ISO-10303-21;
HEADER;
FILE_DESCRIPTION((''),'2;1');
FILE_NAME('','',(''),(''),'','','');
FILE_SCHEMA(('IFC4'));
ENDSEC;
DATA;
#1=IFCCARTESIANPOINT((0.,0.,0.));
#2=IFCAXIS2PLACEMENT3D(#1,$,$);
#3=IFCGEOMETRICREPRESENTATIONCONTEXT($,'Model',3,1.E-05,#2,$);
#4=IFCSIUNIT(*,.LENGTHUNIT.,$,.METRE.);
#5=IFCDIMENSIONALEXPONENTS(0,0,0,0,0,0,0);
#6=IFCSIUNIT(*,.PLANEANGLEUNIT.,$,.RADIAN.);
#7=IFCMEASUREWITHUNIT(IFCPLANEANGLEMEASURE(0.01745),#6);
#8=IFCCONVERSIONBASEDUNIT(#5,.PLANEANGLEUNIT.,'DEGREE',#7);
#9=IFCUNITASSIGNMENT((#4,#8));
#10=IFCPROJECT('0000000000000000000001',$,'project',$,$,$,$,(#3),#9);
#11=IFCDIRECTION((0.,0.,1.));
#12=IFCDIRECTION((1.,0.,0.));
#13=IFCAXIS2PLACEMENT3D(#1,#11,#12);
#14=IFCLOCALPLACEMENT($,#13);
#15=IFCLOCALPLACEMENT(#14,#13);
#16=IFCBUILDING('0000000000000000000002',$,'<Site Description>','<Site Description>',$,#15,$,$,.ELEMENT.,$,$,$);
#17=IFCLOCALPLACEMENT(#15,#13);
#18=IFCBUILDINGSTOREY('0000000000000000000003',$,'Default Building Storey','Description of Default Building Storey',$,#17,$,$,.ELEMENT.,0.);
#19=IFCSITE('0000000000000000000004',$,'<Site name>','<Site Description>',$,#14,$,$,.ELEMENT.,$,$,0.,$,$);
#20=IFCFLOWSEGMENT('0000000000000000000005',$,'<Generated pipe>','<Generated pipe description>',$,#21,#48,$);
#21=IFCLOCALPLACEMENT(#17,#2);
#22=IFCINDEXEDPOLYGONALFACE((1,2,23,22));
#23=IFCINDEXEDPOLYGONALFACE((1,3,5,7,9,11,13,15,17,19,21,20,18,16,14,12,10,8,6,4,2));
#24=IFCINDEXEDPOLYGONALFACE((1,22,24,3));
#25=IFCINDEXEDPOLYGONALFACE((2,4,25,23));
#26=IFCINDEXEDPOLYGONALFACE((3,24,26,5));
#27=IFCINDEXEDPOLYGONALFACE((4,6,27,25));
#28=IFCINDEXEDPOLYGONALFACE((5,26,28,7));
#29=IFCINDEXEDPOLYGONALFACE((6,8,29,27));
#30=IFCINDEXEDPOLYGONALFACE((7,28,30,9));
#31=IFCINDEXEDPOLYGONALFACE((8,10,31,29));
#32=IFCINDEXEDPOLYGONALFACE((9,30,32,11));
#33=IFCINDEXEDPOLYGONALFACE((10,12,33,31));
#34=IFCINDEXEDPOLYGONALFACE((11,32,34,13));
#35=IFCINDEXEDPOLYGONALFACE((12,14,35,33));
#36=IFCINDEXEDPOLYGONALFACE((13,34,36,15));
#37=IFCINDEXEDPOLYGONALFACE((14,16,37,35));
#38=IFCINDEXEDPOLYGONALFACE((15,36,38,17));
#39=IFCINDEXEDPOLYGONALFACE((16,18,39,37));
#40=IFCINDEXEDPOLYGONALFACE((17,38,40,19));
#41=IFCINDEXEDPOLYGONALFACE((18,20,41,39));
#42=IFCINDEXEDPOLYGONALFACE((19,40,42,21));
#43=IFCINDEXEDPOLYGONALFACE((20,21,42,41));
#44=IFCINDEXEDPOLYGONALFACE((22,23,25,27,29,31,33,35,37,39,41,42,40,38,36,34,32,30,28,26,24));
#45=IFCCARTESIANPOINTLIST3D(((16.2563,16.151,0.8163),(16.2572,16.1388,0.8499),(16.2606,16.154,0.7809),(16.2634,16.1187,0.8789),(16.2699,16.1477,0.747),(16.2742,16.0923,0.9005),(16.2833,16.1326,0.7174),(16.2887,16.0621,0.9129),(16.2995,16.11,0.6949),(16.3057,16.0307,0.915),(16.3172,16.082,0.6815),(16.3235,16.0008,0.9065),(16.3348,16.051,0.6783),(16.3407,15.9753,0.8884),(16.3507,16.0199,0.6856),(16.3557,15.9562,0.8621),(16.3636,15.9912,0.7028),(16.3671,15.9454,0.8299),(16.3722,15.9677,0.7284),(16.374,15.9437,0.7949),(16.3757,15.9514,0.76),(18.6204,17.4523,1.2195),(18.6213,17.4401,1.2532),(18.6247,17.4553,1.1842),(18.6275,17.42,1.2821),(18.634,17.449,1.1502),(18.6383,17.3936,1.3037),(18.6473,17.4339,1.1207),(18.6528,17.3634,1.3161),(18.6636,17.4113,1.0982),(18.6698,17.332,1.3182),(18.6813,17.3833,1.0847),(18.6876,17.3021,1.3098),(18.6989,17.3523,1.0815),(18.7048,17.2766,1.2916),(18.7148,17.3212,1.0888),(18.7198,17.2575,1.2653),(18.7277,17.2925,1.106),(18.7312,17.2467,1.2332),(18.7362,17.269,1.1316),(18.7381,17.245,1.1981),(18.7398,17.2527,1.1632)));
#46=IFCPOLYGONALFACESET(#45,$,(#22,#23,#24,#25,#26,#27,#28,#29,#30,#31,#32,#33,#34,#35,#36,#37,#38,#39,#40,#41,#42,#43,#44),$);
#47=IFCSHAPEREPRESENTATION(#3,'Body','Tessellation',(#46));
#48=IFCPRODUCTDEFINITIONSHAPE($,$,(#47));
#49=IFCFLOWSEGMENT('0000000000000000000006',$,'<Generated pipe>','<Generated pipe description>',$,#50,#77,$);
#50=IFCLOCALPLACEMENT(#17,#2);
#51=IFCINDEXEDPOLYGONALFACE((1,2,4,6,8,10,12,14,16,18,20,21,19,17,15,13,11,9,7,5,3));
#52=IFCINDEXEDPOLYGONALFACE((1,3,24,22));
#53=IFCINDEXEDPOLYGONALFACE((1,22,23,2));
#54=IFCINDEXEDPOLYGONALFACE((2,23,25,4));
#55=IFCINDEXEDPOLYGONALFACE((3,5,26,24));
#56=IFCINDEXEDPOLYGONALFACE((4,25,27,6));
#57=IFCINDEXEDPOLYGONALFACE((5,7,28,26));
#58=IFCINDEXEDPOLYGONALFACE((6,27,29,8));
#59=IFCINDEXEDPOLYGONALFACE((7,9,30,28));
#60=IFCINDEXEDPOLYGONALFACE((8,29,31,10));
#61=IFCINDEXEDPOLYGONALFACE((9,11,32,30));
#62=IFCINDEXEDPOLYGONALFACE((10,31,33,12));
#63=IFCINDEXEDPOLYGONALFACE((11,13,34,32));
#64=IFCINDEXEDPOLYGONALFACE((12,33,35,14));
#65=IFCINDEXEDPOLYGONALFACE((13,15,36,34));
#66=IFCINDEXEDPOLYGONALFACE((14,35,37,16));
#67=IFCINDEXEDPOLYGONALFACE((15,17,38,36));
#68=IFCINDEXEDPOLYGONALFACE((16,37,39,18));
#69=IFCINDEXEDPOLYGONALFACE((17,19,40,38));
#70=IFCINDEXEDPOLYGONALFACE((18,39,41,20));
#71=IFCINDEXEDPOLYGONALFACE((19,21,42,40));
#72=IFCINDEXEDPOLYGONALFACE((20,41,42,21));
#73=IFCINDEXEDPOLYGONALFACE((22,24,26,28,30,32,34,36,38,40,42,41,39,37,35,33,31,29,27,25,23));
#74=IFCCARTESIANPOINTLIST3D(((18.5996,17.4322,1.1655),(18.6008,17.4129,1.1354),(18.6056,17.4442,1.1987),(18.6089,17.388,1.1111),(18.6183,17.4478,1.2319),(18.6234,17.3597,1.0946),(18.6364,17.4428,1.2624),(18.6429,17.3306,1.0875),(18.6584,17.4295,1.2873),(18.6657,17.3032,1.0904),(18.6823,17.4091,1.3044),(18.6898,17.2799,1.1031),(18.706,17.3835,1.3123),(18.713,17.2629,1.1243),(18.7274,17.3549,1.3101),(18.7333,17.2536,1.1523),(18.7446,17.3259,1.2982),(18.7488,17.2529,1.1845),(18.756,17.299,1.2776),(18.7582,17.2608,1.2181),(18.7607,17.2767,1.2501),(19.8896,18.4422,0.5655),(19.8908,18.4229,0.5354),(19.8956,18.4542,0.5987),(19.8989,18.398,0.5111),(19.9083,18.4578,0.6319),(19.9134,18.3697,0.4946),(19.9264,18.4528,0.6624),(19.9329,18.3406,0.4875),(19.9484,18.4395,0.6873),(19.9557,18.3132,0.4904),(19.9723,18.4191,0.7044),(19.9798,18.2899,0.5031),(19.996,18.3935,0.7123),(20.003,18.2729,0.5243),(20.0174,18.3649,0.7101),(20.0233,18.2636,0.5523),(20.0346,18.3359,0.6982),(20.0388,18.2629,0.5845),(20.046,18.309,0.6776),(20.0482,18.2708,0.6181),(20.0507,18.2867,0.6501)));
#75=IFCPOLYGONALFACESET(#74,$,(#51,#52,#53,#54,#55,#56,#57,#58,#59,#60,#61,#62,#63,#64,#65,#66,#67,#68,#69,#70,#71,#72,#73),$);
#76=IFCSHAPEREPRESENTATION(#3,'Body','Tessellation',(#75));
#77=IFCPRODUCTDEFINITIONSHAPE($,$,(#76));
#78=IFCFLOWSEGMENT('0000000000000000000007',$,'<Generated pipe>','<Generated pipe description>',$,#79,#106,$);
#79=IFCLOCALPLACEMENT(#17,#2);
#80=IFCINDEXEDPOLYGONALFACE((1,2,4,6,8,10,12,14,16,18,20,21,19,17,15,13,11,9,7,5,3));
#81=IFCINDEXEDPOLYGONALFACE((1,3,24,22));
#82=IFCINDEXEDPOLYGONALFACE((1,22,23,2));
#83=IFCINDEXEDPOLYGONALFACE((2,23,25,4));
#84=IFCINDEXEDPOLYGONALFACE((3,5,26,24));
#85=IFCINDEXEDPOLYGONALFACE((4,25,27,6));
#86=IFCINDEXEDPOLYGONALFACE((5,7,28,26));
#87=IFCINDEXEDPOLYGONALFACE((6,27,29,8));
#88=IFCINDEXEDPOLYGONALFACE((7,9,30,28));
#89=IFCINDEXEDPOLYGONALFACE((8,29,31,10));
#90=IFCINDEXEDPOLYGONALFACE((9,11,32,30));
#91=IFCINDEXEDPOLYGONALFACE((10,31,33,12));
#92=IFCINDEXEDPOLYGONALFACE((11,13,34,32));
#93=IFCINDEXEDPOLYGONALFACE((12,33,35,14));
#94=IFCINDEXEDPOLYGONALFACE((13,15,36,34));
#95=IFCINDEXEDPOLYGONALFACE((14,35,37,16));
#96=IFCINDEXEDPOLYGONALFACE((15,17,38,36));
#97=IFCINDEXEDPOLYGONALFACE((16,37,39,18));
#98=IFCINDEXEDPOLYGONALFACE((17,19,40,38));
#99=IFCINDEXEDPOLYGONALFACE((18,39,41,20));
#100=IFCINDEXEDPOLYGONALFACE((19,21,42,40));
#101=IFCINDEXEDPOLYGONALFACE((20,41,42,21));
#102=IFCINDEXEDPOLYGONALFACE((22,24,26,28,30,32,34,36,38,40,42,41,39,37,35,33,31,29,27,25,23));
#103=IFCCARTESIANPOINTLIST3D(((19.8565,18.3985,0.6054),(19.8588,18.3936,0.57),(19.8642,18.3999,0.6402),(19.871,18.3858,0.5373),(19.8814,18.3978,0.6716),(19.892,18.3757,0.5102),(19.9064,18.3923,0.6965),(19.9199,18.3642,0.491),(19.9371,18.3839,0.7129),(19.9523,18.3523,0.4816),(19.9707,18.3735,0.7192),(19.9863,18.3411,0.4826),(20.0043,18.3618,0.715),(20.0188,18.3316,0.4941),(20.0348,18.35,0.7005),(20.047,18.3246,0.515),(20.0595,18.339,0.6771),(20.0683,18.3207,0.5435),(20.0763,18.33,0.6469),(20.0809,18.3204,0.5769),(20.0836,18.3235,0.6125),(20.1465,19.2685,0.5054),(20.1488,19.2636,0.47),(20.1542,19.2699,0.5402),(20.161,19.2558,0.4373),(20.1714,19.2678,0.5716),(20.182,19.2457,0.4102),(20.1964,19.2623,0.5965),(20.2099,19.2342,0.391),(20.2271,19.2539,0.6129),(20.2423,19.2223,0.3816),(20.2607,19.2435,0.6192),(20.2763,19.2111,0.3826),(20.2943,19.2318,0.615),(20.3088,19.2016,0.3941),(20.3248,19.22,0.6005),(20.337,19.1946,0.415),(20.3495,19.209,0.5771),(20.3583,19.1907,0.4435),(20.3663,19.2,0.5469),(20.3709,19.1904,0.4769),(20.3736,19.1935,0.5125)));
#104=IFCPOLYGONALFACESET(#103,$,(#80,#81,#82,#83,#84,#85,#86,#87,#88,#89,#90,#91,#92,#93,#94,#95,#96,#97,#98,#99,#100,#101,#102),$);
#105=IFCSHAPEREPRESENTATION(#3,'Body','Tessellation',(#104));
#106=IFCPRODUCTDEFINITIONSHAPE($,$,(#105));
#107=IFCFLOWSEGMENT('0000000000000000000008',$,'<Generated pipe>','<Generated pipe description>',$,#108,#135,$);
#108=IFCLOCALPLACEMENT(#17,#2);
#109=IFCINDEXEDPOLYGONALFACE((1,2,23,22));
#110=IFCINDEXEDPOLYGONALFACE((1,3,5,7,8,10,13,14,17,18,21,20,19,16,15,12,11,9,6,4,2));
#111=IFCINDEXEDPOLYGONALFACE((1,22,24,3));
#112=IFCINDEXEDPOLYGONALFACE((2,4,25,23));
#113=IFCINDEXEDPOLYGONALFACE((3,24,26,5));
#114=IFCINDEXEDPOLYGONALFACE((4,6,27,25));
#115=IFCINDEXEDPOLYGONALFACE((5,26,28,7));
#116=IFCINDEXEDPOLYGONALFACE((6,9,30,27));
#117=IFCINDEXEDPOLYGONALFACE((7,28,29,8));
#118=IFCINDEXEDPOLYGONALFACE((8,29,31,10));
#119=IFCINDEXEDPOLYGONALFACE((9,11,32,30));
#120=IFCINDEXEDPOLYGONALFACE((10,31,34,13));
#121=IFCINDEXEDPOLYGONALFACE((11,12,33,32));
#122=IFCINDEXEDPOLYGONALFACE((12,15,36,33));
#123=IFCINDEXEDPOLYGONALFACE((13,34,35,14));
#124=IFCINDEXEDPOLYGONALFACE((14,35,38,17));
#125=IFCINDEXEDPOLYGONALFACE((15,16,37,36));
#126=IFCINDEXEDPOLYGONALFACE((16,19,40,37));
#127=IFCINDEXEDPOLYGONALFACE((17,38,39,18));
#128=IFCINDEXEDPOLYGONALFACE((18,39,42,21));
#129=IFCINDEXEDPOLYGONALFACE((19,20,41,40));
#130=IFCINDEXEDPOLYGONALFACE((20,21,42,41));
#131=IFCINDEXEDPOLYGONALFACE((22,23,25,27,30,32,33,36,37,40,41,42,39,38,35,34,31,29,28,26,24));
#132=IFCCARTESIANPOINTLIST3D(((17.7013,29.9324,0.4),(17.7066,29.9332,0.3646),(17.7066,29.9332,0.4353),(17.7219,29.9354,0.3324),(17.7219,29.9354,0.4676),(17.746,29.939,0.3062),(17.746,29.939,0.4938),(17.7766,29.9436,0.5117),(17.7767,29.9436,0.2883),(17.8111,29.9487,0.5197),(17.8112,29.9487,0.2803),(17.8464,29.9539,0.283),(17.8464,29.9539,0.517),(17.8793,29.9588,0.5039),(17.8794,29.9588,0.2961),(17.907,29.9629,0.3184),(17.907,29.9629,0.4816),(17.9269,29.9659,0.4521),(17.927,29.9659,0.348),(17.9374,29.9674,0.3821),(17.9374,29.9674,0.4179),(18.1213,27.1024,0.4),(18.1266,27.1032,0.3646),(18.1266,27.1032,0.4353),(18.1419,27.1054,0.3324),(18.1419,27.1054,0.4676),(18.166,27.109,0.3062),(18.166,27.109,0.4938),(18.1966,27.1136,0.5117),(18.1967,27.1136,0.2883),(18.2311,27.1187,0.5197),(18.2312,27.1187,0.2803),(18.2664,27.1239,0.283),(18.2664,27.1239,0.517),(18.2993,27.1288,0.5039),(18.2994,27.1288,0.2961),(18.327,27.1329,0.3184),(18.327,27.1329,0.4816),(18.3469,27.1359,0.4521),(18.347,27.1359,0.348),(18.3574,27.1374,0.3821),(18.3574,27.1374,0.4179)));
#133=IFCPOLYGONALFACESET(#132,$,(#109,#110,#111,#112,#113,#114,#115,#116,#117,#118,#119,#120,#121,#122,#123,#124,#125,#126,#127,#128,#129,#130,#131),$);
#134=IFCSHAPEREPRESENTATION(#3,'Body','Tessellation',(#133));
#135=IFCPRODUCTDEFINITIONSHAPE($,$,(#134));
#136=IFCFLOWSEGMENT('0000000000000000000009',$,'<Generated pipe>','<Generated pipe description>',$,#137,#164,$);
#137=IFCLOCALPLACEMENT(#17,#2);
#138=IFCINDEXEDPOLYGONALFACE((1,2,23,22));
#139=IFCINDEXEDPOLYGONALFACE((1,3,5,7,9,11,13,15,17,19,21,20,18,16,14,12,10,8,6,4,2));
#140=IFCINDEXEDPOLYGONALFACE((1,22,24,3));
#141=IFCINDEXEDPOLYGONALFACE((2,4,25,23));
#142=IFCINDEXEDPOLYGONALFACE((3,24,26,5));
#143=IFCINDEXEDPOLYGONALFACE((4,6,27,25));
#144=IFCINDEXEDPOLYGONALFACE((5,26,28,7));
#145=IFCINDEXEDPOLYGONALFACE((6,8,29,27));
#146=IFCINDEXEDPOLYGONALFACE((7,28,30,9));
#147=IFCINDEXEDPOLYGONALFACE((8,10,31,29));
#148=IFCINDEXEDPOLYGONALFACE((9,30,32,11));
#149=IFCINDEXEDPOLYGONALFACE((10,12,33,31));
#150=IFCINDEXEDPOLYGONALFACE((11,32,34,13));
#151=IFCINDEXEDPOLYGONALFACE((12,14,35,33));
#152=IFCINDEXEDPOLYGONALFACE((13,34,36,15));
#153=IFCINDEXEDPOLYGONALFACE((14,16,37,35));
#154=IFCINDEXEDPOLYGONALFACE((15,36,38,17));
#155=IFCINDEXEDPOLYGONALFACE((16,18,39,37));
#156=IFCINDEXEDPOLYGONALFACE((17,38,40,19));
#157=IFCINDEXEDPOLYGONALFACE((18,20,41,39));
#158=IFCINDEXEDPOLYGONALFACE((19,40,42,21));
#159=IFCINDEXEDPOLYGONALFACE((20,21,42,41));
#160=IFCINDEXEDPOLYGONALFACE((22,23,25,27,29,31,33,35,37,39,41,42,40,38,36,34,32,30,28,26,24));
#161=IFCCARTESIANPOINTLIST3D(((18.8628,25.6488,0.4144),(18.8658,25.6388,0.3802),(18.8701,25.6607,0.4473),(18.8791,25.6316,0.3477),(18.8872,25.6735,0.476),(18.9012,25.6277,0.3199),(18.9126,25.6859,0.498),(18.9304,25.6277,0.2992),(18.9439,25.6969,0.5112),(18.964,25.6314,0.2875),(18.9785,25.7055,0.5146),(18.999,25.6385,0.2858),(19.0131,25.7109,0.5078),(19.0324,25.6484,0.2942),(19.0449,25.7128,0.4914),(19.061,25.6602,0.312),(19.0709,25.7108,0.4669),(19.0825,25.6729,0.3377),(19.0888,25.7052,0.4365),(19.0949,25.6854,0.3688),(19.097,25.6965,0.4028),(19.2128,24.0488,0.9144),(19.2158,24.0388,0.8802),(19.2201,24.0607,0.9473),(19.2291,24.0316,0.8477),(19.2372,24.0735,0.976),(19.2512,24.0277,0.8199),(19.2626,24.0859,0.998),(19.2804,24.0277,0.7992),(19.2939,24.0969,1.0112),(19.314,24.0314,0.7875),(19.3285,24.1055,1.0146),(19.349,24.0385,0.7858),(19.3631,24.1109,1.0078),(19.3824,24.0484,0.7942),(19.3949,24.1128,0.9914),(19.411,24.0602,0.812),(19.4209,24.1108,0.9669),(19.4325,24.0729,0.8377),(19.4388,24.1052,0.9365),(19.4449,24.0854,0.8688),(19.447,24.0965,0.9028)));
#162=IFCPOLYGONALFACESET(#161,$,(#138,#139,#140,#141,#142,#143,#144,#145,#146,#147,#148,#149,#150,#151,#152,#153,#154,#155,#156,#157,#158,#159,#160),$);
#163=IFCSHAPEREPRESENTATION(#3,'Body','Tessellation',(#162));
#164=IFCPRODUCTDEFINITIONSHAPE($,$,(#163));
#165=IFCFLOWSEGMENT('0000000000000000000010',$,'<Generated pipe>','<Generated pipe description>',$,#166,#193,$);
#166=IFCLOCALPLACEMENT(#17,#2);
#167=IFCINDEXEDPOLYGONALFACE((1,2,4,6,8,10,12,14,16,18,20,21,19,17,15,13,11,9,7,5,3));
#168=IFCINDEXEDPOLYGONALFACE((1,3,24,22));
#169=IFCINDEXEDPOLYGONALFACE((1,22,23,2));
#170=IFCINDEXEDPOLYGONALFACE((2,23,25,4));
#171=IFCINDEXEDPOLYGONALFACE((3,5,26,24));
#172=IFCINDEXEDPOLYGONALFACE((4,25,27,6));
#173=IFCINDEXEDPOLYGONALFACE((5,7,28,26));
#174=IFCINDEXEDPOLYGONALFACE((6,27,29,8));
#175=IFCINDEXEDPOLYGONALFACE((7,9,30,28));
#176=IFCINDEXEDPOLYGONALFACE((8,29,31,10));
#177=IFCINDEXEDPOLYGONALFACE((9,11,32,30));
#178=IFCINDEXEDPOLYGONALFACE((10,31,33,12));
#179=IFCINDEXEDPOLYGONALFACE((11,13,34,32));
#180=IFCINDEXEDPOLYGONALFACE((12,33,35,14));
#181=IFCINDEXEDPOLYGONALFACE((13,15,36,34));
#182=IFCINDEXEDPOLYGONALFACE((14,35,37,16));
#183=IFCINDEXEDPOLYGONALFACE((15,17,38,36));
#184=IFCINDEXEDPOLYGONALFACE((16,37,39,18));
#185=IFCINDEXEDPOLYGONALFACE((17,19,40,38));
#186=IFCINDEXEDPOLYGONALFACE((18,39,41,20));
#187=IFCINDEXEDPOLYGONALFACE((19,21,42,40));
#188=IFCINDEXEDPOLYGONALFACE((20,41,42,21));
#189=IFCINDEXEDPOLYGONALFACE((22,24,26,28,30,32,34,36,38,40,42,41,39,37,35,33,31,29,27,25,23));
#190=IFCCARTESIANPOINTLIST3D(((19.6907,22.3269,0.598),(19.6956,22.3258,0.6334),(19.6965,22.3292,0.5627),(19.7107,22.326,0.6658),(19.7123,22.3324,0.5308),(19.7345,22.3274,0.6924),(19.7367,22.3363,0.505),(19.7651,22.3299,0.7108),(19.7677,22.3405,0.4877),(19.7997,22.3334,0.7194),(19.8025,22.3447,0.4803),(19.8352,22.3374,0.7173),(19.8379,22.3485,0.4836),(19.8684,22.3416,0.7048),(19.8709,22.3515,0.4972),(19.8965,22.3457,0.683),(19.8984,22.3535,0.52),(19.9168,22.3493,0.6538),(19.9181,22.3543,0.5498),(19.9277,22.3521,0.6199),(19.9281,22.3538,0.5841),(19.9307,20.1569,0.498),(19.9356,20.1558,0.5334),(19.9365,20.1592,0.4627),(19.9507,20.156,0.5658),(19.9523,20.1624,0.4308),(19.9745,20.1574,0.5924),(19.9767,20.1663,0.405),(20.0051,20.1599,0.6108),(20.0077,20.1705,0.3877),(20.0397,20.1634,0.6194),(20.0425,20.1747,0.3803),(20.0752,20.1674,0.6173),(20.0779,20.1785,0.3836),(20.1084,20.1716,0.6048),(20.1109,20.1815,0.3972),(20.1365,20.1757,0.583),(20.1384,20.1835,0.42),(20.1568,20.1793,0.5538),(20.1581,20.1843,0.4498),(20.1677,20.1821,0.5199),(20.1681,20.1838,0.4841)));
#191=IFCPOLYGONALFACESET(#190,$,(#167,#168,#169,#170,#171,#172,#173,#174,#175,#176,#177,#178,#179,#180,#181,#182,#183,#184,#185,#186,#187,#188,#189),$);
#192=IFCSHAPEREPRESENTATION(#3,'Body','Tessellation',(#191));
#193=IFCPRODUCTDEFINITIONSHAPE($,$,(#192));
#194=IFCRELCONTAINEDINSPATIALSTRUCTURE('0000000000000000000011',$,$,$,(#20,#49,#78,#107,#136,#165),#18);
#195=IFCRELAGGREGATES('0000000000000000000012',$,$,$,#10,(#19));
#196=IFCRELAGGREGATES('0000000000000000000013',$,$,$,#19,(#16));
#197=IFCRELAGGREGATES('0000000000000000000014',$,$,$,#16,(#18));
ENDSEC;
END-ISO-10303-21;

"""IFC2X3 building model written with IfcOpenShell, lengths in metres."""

from ifc_helpers import new_model, entity, si_unit, converted_unit, frame, origin, origin_with_axes, origin_2d_with_axis, place, context, project, spatial, circle, extrude, element, save


model = new_model("IFC2X3")

# Units and contexts
model_context = context("Model", 3, precision=1e-05, world=origin())
ifc_project = project(units=[si_unit("LENGTHUNIT", "METRE"), converted_unit("PLANEANGLEUNIT", "DEGREE", entity("IfcPlaneAngleMeasure", 0.01745), si_unit("PLANEANGLEUNIT", "RADIAN"), dimensions=[0, 0, 0, 0, 0, 0, 0])], contexts=[model_context])

# Site, building, storey
site_placement = place(None, origin_with_axes())
site = spatial("IfcSite", under=ifc_project, at=site_placement, Name="<Site name>", Description="<Site Description>", CompositionType="ELEMENT", RefElevation=0.0)
building_placement = place(site_placement, origin_with_axes())
building = spatial("IfcBuilding", under=site, at=building_placement, Name="<Site Description>", Description="<Site Description>", CompositionType="ELEMENT")
storey_placement = place(building_placement, origin_with_axes())
storey = spatial("IfcBuildingStorey", under=building, at=storey_placement, Name="Default Building Storey", Description="Description of Default Building Storey", CompositionType="ELEMENT", Elevation=0.0)

# Flow segments
flow_segment_1_placement = place(storey_placement, frame((16.3159, 16.0487, 0.7968), z_axis=(0.866431, 0.476923, 0.147786), x_axis=(-0.347597, 0.363676, 0.864243)))
element("IfcFlowSegment", 1, at=flow_segment_1_placement, inside=storey, Name="<Generated pipe>", Description="<Generated pipe description>", context=model_context, shape_type="SweptSolid", body=[
    extrude(circle(Radius=0.12, at=origin_2d_with_axis()), origin_with_axes(), (0.0, 0.0, 1.0), 2.7285),
])
flow_segment_2_placement = place(storey_placement, frame((18.68, 17.35, 1.2), z_axis=(0.739355, 0.578875, -0.343886), x_axis=(0.018908, 0.492684, 0.870003)))
element("IfcFlowSegment", 2, at=flow_segment_2_placement, inside=storey, Name="<Generated pipe>", Description="<Generated pipe description>", context=model_context, shape_type="SweptSolid", body=[
    extrude(circle(Radius=0.12, at=origin_2d_with_axis()), origin_with_axes(), (0.0, 0.0, 1.0), 1.7448),
])
flow_segment_3_placement = place(storey_placement, frame((19.97, 18.36, 0.6), z_axis=(0.314364, 0.943093, -0.108401), x_axis=(0.005926, 0.112239, 0.993664)))
element("IfcFlowSegment", 3, at=flow_segment_3_placement, inside=storey, Name="<Generated pipe>", Description="<Generated pipe description>", context=model_context, shape_type="SweptSolid", body=[
    extrude(circle(Radius=0.12, at=origin_2d_with_axis()), origin_with_axes(), (0.0, 0.0, 1.0), 0.9225),
])
flow_segment_4_placement = place(storey_placement, frame((17.82, 29.95, 0.4), z_axis=(0.146802, -0.989166, 0.0), x_axis=(0.494372, 0.07337, 0.866148)))
element("IfcFlowSegment", 4, at=flow_segment_4_placement, inside=storey, Name="<Generated pipe>", Description="<Generated pipe description>", context=model_context, shape_type="SweptSolid", body=[
    extrude(circle(Radius=0.12, at=origin_2d_with_axis()), origin_with_axes(), (0.0, 0.0, 1.0), 2.861),
])
flow_segment_5_placement = place(storey_placement, frame((18.98, 25.67, 0.4), z_axis=(0.204385, -0.934331, 0.291979), x_axis=(0.540757, 0.356399, 0.761946)))
element("IfcFlowSegment", 5, at=flow_segment_5_placement, inside=storey, Name="<Generated pipe>", Description="<Generated pipe description>", context=model_context, shape_type="SweptSolid", body=[
    extrude(circle(Radius=0.12, at=origin_2d_with_axis()), origin_with_axes(), (0.0, 0.0, 1.0), 1.7125),
])
flow_segment_6_placement = place(storey_placement, frame((19.81, 22.34, 0.6), z_axis=(0.109814, -0.992898, -0.045756), x_axis=(0.981016, 0.100867, 0.165629)))
element("IfcFlowSegment", 6, at=flow_segment_6_placement, inside=storey, Name="<Generated pipe>", Description="<Generated pipe description>", context=model_context, shape_type="SweptSolid", body=[
    extrude(circle(Radius=0.12, at=origin_2d_with_axis()), origin_with_axes(), (0.0, 0.0, 1.0), 2.1855),
])

save(model, "model.ifc")
